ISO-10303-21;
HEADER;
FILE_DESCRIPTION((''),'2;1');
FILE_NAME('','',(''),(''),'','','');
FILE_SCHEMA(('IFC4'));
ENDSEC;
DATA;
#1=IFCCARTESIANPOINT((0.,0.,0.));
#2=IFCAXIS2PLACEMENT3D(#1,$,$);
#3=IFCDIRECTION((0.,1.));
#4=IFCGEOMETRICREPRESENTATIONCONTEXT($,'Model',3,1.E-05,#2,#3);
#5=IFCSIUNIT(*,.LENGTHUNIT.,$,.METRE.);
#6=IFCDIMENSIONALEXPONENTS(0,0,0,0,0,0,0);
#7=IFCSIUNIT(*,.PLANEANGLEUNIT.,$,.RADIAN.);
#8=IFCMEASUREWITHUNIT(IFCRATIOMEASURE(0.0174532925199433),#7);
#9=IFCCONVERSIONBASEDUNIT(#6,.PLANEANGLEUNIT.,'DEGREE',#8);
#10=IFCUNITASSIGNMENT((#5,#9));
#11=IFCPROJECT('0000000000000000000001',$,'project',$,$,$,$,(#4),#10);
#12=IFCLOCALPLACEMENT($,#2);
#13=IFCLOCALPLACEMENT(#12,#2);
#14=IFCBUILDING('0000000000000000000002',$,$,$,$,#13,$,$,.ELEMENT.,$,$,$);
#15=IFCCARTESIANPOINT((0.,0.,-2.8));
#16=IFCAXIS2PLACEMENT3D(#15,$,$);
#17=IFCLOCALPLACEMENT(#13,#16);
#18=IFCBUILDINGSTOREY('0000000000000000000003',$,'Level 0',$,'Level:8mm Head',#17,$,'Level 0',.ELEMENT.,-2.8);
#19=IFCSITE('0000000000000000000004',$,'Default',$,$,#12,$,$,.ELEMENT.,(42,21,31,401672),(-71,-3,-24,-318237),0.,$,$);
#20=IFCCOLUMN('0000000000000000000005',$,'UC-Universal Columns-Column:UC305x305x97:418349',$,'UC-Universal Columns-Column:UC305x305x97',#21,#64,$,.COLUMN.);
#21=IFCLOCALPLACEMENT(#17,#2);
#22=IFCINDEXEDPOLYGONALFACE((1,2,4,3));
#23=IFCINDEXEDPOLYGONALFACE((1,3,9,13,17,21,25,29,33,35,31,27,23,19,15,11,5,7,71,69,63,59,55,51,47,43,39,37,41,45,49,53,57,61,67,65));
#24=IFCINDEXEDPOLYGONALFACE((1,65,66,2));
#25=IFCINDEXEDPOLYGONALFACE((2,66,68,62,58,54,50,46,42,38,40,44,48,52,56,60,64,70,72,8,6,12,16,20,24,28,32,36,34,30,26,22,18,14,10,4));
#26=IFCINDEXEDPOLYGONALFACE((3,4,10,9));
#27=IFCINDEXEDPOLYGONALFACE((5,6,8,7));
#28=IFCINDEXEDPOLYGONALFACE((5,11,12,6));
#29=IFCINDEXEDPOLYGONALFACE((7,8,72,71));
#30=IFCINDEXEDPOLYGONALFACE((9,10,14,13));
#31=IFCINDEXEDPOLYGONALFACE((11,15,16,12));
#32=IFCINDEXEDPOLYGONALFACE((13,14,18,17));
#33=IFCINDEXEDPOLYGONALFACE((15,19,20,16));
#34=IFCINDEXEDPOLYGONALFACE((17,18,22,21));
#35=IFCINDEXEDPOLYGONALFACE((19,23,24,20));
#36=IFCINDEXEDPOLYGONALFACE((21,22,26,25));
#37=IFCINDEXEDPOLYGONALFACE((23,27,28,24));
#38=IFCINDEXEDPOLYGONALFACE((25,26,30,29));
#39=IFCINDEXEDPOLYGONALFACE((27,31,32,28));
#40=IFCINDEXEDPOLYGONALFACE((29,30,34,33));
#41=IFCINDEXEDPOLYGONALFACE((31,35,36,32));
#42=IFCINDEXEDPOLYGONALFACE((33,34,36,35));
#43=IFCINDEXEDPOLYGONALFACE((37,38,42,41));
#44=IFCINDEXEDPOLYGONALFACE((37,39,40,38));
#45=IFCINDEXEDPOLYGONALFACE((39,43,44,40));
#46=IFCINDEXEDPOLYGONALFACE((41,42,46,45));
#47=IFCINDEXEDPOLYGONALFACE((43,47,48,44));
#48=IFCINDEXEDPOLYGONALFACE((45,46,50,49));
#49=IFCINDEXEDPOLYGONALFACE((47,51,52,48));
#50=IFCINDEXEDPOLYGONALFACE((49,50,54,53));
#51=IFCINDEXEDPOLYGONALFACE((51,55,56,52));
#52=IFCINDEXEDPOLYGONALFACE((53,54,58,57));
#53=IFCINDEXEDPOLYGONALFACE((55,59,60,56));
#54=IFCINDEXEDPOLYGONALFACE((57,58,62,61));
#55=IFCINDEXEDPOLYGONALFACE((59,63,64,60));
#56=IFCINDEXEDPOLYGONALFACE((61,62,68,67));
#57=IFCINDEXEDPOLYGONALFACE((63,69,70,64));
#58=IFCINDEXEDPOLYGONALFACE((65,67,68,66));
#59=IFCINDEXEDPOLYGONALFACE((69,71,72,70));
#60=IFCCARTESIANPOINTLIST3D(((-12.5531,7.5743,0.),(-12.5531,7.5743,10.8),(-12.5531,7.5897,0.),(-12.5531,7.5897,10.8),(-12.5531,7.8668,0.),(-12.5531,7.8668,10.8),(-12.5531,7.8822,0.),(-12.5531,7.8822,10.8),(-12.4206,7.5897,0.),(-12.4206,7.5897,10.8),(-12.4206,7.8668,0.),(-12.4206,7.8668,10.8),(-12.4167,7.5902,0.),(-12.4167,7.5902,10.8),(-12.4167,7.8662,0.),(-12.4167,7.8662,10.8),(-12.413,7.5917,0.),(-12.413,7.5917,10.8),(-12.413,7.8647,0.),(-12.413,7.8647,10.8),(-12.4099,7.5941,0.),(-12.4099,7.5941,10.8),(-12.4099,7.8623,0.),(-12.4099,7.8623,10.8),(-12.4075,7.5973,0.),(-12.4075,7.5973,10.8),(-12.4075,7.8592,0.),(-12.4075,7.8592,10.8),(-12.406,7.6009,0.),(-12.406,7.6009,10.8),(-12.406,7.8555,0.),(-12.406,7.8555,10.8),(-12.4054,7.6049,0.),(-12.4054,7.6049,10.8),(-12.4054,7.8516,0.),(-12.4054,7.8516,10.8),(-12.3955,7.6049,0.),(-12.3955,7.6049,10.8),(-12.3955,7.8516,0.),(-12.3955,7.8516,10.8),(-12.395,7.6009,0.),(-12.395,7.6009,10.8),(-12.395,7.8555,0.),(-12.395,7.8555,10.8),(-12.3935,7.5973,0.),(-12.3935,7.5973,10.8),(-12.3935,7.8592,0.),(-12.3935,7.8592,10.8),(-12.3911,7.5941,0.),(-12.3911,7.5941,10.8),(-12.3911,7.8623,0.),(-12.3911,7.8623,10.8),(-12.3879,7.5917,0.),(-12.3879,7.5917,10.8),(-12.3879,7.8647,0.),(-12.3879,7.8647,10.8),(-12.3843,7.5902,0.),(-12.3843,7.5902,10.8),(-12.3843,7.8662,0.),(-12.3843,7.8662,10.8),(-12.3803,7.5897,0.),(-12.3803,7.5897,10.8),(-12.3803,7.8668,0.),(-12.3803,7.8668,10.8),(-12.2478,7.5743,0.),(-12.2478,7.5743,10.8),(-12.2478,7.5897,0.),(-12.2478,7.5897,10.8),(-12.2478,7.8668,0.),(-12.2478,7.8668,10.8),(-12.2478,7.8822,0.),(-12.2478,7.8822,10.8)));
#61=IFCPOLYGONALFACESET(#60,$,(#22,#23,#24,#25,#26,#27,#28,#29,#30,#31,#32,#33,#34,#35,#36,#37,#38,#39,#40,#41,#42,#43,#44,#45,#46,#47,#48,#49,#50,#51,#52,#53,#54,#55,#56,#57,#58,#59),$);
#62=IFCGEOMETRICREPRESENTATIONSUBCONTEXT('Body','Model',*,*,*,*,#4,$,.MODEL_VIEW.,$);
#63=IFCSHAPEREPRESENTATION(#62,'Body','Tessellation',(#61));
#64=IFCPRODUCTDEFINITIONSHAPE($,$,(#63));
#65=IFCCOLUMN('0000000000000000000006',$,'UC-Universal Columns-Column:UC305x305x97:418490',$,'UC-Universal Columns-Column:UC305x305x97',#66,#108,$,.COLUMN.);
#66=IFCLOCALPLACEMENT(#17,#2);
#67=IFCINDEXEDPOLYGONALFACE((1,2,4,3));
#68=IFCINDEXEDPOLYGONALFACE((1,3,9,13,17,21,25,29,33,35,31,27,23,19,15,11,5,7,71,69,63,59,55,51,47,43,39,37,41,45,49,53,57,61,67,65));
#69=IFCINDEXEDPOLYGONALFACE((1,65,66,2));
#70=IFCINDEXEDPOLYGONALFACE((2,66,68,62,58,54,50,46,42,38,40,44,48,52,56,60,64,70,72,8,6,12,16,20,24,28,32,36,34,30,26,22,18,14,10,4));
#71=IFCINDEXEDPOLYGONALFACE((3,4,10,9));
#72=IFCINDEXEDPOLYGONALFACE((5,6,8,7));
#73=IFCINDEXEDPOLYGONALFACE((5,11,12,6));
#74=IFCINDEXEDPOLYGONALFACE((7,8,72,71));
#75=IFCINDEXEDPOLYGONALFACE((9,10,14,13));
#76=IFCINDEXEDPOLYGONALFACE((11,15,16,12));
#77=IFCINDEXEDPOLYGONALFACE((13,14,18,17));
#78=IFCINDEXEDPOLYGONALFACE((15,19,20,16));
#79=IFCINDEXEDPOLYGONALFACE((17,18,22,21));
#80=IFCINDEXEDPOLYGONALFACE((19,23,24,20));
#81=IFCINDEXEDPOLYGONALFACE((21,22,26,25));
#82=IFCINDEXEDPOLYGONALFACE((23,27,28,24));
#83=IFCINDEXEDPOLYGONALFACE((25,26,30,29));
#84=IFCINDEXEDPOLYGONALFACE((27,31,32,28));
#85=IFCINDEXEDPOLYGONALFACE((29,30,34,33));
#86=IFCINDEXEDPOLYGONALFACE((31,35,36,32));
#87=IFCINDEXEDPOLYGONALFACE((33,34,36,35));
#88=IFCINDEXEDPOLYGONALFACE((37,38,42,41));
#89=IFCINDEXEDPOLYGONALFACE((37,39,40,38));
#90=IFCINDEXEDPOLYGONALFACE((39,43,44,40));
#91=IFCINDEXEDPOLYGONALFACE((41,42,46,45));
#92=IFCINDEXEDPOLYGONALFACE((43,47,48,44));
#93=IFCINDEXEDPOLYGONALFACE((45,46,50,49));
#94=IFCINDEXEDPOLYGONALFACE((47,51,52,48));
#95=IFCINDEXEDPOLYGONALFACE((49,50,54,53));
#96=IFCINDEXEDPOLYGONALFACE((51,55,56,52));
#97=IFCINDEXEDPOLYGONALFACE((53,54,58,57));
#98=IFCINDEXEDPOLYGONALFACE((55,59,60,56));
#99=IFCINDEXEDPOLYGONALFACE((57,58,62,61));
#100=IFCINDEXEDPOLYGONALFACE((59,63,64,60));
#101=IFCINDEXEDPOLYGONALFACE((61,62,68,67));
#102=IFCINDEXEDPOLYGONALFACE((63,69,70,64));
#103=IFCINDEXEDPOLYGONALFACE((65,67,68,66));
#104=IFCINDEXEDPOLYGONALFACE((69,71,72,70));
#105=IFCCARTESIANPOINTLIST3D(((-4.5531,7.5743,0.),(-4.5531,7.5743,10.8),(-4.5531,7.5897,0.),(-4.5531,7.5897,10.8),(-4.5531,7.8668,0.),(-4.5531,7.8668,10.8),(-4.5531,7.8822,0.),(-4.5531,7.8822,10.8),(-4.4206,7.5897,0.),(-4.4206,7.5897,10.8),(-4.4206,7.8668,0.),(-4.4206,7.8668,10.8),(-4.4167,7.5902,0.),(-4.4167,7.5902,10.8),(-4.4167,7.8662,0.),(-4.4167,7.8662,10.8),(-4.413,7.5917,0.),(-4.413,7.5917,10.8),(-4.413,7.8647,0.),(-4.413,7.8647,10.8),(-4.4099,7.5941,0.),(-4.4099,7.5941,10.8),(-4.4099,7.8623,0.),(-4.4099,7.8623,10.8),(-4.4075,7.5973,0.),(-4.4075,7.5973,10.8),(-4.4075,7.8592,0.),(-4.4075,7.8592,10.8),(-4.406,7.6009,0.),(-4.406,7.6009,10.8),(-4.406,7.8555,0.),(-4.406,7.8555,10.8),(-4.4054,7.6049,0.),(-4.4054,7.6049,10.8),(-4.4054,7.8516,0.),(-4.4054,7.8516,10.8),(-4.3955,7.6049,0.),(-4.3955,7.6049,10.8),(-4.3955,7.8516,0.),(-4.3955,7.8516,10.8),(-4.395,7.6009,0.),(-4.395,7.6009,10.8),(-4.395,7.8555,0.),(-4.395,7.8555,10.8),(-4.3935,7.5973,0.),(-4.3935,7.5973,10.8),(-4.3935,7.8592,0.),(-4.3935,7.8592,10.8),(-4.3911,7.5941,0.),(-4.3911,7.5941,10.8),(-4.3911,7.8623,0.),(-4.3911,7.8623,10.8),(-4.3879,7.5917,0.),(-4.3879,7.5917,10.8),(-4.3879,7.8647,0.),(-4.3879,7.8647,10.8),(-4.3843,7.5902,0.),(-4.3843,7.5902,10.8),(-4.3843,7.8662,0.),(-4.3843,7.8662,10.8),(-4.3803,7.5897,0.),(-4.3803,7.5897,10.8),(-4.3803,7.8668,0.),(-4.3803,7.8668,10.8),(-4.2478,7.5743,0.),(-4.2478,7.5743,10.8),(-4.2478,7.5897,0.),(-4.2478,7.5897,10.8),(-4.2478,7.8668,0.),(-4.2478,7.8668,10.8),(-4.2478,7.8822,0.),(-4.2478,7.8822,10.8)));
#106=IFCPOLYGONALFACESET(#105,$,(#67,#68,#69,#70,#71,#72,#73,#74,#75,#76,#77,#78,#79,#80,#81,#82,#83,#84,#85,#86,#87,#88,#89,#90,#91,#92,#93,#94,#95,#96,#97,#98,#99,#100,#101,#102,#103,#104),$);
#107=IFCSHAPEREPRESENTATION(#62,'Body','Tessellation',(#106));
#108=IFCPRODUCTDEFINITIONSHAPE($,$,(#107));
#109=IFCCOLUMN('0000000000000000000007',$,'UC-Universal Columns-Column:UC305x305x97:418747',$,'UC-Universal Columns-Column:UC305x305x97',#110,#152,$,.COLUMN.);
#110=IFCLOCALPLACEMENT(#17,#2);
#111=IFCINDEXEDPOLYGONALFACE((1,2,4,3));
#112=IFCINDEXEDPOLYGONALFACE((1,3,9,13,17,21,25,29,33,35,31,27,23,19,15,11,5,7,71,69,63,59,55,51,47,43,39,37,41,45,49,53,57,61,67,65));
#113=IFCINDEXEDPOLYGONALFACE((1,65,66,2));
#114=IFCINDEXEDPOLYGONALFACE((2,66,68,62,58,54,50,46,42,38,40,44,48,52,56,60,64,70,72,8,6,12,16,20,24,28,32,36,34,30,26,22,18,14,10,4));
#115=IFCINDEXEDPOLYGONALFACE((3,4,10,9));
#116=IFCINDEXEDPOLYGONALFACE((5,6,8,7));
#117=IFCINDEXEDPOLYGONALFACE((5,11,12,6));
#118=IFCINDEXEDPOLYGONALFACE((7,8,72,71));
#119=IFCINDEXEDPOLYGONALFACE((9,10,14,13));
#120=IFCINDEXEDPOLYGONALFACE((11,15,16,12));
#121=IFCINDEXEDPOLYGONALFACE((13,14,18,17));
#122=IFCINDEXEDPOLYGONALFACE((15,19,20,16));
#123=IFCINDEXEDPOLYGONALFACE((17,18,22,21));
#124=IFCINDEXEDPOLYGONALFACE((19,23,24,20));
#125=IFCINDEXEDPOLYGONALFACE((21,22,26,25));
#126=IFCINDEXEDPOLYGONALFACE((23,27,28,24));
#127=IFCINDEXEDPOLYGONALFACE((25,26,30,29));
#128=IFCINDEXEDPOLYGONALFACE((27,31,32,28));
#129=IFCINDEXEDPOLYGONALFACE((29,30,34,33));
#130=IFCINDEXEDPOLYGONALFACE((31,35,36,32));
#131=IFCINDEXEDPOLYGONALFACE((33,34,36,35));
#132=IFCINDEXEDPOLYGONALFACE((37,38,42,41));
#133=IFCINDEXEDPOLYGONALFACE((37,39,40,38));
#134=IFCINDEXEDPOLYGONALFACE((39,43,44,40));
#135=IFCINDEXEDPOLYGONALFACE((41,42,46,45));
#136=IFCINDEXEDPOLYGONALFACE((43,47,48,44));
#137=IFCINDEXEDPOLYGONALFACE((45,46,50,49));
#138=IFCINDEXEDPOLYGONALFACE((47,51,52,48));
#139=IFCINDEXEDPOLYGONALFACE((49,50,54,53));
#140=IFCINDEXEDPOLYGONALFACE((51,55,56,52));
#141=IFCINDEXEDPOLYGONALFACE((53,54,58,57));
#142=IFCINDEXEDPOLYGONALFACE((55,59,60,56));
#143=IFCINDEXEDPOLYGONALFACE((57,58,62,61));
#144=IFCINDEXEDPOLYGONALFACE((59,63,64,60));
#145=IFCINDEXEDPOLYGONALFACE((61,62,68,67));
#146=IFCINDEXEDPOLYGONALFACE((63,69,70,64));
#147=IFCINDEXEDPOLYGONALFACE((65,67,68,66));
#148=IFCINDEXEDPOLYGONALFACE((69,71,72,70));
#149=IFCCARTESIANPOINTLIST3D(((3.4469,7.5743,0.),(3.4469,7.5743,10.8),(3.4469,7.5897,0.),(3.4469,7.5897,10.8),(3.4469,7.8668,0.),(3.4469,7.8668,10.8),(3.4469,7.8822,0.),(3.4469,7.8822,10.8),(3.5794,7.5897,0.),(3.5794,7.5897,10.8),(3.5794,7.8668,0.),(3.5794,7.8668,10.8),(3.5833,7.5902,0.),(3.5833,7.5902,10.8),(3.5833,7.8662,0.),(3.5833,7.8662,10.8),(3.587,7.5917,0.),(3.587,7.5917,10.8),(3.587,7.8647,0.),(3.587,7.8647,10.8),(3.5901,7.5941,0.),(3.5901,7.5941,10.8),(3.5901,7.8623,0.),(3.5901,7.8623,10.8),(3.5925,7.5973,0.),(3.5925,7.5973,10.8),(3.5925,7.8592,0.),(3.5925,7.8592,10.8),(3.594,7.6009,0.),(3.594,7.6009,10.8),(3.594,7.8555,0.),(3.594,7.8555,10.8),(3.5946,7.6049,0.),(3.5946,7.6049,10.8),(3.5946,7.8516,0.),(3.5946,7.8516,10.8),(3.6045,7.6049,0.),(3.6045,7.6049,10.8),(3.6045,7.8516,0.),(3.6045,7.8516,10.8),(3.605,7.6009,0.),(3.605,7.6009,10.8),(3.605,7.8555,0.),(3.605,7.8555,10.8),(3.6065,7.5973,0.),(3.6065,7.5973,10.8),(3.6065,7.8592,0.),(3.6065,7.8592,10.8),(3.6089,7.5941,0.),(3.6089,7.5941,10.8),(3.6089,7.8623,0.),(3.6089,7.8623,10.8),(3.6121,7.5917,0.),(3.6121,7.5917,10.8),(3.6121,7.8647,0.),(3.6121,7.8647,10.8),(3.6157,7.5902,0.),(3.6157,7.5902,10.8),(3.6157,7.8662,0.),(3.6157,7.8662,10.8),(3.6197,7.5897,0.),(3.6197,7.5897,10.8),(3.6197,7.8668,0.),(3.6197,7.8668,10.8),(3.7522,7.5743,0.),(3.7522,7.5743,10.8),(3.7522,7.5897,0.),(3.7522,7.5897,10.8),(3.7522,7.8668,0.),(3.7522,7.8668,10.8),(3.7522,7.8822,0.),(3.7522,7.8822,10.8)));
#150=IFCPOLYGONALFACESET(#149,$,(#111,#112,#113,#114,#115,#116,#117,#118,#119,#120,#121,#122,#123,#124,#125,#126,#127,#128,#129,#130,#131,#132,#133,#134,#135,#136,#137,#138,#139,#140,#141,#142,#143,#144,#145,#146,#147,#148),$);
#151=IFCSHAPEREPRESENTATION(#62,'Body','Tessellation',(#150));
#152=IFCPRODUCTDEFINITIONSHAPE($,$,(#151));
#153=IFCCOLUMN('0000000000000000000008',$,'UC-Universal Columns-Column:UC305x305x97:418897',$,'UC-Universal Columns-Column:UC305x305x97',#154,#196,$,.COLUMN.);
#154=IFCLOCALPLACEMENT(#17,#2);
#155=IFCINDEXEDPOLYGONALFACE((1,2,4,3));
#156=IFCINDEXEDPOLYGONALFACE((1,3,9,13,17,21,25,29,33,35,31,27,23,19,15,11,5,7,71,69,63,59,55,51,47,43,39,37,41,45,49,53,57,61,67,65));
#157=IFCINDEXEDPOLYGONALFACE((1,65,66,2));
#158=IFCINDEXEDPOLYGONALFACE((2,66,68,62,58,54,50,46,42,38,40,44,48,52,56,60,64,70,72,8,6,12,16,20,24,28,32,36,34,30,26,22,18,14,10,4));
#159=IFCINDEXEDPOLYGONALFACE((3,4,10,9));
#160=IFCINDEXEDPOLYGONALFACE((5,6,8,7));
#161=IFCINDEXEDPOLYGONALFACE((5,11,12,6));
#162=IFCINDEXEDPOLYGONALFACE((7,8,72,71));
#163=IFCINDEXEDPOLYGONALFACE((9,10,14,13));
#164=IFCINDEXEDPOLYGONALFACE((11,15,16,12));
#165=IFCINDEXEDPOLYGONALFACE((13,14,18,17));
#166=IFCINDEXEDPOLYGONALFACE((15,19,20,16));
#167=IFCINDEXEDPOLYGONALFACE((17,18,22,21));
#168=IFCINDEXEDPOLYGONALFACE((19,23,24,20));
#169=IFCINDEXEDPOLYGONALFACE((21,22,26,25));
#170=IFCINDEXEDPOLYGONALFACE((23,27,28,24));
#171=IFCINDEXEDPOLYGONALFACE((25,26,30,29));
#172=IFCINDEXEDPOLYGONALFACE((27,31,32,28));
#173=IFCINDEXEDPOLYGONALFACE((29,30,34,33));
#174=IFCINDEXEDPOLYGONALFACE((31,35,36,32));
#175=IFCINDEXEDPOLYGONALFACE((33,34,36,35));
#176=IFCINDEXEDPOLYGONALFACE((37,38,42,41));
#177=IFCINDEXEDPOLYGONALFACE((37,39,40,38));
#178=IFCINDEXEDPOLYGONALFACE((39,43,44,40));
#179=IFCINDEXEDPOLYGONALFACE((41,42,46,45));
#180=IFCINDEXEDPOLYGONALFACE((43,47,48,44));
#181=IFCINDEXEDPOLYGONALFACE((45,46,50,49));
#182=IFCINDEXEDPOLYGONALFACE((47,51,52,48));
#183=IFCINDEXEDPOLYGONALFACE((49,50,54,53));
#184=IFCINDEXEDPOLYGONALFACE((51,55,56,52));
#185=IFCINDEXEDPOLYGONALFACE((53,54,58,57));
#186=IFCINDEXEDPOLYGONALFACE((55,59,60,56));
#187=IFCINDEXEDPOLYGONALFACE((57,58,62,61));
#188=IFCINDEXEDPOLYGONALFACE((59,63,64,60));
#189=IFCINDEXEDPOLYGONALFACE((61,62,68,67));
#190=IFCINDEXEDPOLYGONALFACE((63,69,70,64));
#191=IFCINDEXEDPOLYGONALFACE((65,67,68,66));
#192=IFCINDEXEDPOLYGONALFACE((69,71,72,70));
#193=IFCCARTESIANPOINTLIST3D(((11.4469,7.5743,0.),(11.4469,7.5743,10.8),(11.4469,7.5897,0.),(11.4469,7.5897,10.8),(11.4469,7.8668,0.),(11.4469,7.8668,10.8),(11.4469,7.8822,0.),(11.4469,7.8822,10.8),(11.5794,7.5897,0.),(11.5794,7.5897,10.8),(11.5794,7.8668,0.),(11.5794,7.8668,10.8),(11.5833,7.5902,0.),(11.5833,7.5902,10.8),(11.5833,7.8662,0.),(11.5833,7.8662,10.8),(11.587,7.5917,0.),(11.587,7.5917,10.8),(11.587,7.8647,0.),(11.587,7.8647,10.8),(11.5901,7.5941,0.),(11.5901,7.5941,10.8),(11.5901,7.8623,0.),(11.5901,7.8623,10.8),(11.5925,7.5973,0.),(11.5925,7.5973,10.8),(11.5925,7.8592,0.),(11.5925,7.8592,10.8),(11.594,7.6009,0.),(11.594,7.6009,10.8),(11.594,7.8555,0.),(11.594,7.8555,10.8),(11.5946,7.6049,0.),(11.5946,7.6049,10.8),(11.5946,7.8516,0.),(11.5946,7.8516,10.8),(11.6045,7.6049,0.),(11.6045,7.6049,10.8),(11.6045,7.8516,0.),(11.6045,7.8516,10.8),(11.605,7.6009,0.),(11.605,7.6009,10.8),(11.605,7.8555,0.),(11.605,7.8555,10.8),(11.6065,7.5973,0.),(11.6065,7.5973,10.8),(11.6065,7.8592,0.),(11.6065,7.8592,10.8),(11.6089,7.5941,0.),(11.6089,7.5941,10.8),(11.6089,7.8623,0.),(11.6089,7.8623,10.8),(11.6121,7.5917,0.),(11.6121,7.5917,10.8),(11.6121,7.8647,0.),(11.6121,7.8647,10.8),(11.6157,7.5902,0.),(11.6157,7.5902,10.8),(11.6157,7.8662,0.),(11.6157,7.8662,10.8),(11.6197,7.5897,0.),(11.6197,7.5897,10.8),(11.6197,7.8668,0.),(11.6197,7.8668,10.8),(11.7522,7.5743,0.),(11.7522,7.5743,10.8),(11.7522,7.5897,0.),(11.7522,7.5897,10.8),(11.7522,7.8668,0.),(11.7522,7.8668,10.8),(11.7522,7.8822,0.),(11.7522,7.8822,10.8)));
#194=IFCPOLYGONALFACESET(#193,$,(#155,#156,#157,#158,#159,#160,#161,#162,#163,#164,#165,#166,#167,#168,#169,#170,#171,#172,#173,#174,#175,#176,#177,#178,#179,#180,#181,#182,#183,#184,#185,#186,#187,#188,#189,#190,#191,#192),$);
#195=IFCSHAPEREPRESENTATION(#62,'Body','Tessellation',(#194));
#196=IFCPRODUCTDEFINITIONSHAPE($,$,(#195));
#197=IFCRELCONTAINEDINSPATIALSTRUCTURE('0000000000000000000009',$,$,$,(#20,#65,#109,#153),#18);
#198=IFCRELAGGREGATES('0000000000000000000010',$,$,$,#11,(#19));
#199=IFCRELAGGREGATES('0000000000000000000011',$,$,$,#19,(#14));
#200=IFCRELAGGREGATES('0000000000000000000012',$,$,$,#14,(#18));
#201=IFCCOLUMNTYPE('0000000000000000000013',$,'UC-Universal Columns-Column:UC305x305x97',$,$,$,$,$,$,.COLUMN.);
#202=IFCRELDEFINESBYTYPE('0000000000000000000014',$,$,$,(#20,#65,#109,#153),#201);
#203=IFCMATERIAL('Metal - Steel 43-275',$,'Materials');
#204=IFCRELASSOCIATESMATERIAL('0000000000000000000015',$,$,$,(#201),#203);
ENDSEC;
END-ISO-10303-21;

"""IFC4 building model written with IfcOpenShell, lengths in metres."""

from ifc_helpers import new_model, entity, si_unit, converted_unit, direction, frame, frame_2d, origin, place, context, subcontext, project, spatial, i_section, extrude, source, transform, mapped, material, material_profile, profile_set, type_object, type_shapes, element, save


model = new_model("IFC4")

# Units and contexts
model_context = context("Model", 3, precision=1e-05, world=origin(), true_north=direction((0.0, 1.0)))
body_context = subcontext(model_context, "Body", "Model", "MODEL_VIEW")
ifc_project = project(units=[si_unit("LENGTHUNIT", "METRE"), converted_unit("PLANEANGLEUNIT", "DEGREE", entity("IfcRatioMeasure", 0.0174532925199433), si_unit("PLANEANGLEUNIT", "RADIAN"), dimensions=[0, 0, 0, 0, 0, 0, 0])], contexts=[model_context])

# Site, building, storey
site_placement = place(None, origin())
site = spatial("IfcSite", under=ifc_project, at=site_placement, Name="Default", CompositionType="ELEMENT", RefLatitude=(42, 21, 31, 401672), RefLongitude=(-71, -3, -24, -318237), RefElevation=0.0)
building_placement = place(site_placement, origin())
building = spatial("IfcBuilding", under=site, at=building_placement, CompositionType="ELEMENT")
storey_placement = place(building_placement, frame((0.0, 0.0, -2.8)))
storey = spatial("IfcBuildingStorey", under=building, at=storey_placement, Name="Level 0", ObjectType="Level:8mm Head", LongName="Level 0", CompositionType="ELEMENT", Elevation=-2.8)

# Columns
ifc_material_1 = material(Name="Metal - Steel 43-275", Category="Materials")
ifc_material_profile = material_profile(ifc_material_1, i_section(OverallWidth=0.3053, OverallDepth=0.3079, WebThickness=0.0099, FlangeThickness=0.0154, FilletRadius=0.0152, at=frame_2d((0.0, 0.0), x_axis=(0.0, 1.0))), Name="UC305x305x97")
ifc_profile_set = profile_set([ifc_material_profile], Name="UC305x305x97")
column_type = type_object("IfcColumnType", Name="UC-Universal Columns-Column:UC305x305x97", PredefinedType="COLUMN", material=ifc_profile_set)
shared_shape = source(origin(), body_context, "Body", "SweptSolid", [
    extrude(i_section(OverallWidth=0.3053, OverallDepth=0.3079, WebThickness=0.0099, FlangeThickness=0.0154, FilletRadius=0.0152, at=frame_2d((0.0, 0.0), x_axis=(0.0, 1.0))), frame((0.0, 0.0, -2.8), z_axis=(0.0, 0.0, 1.0), x_axis=(0.0, -1.0, 0.0)), (0.0, 0.0, 1.0), 10.8),
])
type_shapes(column_type, [shared_shape])
for number, where, name in (
    (1, (-12.4005, 7.7282, 2.8), "UC-Universal Columns-Column:UC305x305x97:418349"),
    (2, (-4.4005, 7.7282, 2.8), "UC-Universal Columns-Column:UC305x305x97:418490"),
    (3, (3.5995, 7.7282, 2.8), "UC-Universal Columns-Column:UC305x305x97:418747"),
    (4, (11.5995, 7.7282, 2.8), "UC-Universal Columns-Column:UC305x305x97:418897"),
):
    element("IfcColumn", number, at=place(storey_placement, frame(where)), inside=storey, type_object=column_type, Name=name, ObjectType="UC-Universal Columns-Column:UC305x305x97", PredefinedType="COLUMN", context=body_context, shape_type="MappedRepresentation", body=[
        mapped(shared_shape, transform((0.0, 0.0, 0.0), scale=1.0)),
    ])

save(model, "model.ifc")
